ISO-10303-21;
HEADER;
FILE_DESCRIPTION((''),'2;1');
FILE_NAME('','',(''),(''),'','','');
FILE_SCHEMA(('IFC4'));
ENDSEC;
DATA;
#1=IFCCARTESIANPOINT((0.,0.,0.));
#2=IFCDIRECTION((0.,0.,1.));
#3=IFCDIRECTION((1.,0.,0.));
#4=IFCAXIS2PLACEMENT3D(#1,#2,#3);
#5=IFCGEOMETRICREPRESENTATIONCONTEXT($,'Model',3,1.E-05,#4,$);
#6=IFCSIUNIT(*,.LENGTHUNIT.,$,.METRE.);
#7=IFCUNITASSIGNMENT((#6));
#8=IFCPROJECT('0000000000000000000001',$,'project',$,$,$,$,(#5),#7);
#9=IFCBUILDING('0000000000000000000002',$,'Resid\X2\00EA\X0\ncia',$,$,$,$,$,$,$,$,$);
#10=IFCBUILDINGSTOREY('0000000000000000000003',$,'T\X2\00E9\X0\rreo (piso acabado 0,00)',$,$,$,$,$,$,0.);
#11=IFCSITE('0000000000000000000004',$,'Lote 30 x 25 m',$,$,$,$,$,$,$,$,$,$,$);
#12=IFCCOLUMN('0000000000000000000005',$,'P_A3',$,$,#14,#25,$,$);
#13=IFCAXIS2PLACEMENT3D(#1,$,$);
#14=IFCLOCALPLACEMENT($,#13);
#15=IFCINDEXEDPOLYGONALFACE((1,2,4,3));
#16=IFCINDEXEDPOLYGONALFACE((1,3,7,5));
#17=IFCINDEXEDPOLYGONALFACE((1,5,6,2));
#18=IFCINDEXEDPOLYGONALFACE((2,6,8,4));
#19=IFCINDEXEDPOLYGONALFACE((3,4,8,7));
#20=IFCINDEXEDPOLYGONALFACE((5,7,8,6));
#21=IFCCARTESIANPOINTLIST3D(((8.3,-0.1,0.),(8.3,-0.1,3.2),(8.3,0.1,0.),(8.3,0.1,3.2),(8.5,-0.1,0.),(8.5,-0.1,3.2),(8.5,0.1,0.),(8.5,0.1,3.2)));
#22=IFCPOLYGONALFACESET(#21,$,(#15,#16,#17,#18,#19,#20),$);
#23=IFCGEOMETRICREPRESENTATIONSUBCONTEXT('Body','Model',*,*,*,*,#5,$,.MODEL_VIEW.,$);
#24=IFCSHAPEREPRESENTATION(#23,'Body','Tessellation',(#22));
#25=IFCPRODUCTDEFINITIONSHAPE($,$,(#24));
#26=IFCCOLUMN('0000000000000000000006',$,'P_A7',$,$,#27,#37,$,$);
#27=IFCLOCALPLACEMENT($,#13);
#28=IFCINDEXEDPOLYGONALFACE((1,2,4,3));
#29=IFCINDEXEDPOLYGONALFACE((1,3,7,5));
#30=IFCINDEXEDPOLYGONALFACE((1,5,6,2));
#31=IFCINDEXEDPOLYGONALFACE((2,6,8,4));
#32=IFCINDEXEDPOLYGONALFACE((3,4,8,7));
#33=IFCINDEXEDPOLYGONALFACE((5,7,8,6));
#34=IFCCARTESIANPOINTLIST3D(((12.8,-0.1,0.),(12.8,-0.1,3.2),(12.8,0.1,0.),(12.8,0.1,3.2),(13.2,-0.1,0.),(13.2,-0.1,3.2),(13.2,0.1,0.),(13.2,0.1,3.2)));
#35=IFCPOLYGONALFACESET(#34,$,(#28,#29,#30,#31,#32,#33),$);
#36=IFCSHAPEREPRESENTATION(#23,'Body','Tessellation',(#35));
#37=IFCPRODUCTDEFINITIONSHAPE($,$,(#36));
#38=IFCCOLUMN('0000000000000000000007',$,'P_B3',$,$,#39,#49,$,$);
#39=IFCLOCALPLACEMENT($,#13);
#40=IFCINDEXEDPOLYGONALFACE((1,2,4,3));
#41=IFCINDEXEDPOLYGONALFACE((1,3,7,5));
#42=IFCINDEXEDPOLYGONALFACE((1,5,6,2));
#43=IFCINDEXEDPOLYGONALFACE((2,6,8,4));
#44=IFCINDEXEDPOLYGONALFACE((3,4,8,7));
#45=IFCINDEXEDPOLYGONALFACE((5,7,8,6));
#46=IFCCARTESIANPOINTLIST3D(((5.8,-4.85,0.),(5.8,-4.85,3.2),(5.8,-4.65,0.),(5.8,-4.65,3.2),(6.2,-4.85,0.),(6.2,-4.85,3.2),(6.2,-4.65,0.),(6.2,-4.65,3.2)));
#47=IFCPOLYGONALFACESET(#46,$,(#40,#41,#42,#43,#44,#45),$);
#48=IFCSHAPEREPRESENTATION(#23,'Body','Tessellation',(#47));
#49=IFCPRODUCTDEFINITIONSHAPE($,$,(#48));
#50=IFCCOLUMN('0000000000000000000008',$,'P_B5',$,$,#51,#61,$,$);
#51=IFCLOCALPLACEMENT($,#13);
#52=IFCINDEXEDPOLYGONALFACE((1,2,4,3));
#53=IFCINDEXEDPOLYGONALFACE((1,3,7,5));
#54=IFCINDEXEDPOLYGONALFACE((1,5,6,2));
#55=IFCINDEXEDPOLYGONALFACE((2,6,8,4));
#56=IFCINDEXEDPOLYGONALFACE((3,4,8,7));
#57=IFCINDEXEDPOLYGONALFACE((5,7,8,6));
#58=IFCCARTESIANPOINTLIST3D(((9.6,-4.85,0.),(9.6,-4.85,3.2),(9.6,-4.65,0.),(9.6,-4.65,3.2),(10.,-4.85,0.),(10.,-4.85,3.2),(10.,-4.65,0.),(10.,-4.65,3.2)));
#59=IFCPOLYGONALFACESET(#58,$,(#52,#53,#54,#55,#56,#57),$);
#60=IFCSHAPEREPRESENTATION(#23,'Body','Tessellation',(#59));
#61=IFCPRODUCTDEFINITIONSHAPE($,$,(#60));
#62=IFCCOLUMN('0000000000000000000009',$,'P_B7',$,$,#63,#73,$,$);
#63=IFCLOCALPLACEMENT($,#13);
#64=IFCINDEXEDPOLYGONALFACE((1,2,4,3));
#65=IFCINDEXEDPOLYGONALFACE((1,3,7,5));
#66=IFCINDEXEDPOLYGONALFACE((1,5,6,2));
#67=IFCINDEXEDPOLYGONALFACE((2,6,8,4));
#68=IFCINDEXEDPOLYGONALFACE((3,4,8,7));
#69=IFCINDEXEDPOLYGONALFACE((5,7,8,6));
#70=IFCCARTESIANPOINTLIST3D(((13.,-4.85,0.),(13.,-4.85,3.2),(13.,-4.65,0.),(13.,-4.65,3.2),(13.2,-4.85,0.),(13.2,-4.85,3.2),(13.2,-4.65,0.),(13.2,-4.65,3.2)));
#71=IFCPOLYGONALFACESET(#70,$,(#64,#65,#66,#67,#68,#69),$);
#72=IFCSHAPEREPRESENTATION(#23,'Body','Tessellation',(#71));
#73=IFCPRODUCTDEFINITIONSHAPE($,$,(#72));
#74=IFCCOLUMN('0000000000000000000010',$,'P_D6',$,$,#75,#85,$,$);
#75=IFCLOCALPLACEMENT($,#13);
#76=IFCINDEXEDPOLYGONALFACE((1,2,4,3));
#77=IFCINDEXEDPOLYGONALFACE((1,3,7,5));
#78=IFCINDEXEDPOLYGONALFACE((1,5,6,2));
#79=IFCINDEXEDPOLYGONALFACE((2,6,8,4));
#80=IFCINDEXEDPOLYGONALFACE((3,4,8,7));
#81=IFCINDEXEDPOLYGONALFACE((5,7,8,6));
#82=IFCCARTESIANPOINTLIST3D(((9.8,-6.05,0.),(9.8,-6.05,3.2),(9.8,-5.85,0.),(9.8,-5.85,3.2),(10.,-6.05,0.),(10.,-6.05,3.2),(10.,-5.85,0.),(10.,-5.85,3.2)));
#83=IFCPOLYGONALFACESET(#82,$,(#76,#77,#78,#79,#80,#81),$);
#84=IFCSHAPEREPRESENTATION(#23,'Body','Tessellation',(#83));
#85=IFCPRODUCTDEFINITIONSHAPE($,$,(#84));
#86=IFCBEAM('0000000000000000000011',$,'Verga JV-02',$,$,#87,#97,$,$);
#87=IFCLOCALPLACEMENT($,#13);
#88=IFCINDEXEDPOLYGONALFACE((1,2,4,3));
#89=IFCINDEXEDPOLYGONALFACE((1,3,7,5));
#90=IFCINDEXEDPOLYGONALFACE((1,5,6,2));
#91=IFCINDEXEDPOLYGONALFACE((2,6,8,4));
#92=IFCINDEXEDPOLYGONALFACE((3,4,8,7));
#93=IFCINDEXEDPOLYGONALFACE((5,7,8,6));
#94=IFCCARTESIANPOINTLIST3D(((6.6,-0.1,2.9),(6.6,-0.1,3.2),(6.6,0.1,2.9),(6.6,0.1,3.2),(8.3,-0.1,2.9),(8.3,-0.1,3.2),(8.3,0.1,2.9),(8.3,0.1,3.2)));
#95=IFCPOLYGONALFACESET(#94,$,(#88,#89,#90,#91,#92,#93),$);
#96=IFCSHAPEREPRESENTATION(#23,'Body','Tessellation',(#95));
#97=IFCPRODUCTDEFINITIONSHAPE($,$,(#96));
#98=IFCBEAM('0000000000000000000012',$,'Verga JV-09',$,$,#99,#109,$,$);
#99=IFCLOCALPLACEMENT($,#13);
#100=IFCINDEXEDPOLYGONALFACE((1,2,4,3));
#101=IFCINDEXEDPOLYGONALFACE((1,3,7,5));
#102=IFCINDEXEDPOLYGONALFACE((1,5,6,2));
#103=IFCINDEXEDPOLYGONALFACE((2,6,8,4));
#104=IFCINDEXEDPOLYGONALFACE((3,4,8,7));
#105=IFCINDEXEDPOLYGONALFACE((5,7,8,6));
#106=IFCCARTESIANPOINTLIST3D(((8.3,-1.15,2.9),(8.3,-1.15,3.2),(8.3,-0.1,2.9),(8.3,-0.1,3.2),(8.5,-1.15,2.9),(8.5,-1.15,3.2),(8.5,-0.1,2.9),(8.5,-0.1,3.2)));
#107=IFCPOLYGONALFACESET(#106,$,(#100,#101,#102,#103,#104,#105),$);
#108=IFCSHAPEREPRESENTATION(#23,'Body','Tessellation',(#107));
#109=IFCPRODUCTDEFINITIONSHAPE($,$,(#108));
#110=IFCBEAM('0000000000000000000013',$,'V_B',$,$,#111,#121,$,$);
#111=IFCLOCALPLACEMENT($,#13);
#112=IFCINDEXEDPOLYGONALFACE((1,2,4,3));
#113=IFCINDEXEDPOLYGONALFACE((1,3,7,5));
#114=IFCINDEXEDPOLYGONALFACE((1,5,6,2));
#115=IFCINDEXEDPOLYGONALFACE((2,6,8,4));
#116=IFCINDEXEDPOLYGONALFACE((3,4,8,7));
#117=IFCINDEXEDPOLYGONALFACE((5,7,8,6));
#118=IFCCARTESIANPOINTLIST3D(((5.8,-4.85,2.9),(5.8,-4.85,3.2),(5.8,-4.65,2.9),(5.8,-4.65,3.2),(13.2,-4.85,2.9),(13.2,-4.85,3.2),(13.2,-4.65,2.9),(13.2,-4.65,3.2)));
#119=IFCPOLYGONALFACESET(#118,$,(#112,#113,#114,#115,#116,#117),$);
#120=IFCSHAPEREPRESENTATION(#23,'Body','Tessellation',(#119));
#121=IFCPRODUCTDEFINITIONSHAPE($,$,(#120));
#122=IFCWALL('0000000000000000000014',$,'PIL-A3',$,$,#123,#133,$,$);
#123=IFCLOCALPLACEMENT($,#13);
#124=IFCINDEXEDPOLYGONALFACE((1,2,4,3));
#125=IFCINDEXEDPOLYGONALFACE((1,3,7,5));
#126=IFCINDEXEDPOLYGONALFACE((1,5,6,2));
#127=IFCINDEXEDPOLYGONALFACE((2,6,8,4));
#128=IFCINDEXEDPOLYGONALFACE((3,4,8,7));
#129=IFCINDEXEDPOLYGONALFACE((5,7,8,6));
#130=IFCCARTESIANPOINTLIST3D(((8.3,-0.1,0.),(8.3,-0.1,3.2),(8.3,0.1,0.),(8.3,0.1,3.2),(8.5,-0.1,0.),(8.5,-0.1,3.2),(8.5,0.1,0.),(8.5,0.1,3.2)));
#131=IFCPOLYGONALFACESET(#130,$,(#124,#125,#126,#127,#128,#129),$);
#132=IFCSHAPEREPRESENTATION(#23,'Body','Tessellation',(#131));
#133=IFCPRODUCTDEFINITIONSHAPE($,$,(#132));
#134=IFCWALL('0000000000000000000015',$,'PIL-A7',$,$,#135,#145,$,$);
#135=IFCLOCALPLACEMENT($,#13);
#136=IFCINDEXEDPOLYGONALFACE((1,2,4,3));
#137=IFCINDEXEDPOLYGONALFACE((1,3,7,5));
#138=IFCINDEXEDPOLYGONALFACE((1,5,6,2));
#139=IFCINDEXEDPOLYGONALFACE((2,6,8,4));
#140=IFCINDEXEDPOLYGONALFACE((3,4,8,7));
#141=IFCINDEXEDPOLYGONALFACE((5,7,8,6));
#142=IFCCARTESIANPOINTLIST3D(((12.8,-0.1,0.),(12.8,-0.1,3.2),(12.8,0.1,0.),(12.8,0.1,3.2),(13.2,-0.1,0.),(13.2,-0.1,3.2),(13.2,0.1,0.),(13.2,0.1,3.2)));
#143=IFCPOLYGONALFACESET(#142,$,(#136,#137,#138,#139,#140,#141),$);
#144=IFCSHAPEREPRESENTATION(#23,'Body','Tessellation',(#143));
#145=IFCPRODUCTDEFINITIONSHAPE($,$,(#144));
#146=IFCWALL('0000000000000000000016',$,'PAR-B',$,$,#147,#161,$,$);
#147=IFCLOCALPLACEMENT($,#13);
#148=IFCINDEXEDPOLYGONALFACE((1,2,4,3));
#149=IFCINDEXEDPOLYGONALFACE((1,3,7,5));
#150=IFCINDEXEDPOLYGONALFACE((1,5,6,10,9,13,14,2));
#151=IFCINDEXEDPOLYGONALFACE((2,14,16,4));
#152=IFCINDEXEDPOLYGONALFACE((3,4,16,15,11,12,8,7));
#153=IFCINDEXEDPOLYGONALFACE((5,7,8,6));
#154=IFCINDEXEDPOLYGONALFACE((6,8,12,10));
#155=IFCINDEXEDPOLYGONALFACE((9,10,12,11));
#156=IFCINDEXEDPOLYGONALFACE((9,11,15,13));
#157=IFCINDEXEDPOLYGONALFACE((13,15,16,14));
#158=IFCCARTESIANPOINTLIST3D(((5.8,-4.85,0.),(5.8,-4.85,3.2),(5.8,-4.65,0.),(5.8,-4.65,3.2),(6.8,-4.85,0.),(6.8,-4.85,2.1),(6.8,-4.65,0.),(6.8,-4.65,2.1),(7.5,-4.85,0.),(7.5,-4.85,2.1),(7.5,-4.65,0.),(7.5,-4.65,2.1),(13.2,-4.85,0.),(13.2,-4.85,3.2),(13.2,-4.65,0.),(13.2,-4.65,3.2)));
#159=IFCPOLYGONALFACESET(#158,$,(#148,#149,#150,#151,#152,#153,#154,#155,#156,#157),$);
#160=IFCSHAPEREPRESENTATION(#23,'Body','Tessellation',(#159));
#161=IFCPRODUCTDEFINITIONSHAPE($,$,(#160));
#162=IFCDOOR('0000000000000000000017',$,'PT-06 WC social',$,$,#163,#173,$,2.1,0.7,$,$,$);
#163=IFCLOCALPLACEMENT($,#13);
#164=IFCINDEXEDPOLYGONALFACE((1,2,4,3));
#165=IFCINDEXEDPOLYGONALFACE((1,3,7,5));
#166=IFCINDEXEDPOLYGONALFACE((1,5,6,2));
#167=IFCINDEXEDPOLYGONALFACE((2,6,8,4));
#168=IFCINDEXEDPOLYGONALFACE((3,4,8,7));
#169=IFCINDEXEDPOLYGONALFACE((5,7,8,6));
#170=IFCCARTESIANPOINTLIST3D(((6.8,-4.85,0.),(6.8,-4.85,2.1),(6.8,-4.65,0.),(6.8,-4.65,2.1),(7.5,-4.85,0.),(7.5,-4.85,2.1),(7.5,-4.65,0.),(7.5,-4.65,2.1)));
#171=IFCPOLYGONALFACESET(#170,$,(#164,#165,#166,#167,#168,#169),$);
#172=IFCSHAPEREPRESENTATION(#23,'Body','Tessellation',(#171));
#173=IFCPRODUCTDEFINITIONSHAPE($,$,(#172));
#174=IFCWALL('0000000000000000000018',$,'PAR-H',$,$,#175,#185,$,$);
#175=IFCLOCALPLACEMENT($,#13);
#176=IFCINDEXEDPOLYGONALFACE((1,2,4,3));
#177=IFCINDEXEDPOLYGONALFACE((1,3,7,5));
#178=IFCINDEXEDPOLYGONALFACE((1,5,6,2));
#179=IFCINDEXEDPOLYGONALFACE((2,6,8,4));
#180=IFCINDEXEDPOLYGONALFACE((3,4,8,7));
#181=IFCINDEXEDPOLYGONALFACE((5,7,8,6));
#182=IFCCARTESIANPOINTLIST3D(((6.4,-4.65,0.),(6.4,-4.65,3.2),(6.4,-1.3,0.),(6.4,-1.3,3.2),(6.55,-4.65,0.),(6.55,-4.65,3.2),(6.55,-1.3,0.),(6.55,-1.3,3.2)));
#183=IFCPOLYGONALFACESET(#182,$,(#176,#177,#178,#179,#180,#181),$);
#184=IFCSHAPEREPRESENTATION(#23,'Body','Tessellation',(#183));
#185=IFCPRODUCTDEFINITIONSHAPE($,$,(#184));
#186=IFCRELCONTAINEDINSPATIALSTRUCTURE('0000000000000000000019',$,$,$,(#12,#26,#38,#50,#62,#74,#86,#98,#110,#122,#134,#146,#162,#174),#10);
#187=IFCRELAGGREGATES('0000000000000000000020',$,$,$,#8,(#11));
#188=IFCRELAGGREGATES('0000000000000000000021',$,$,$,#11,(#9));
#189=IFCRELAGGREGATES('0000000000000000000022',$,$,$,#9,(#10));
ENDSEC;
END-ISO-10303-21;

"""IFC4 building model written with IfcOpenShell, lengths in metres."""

from ifc_helpers import new_model, si_unit, frame, origin_with_axes, place, context, subcontext, project, spatial, line, indexed_curve, outline, extrude, element, fill, save


model = new_model("IFC4")

# Units and contexts
model_context = context("Model", 3, precision=1e-05, world=origin_with_axes())
body_context = subcontext(model_context, "Body", "Model", "MODEL_VIEW")
ifc_project = project(units=[si_unit("LENGTHUNIT", "METRE")], contexts=[model_context])

# Site, building, storey
site = spatial("IfcSite", under=ifc_project, Name="Lote 30 x 25 m")
building = spatial("IfcBuilding", under=site, Name="Residência")
storey = spatial("IfcBuildingStorey", under=building, Name="Térreo (piso acabado 0,00)", Elevation=0.0)

# Columns
column_1_placement = place(None, frame((8.3, -0.1, 0.0), z_axis=(0.0, 0.0, 1.0), x_axis=(1.0, 0.0, 0.0)))
element("IfcColumn", 1, at=column_1_placement, inside=storey, Name="P_A3", context=body_context, shape_type="SweptSolid", body=[
    extrude(outline(indexed_curve([(0.0, 0.0), (0.2, 0.0), (0.2, 0.2), (0.0, 0.2)], segments=[line(1, 2, 3, 4, 1)])), origin_with_axes(), (0.0, 0.0, 1.0), 3.2),
])
column_2_placement = place(None, frame((12.8, -0.1, 0.0), z_axis=(0.0, 0.0, 1.0), x_axis=(1.0, 0.0, 0.0)))
element("IfcColumn", 2, at=column_2_placement, inside=storey, Name="P_A7", context=body_context, shape_type="SweptSolid", body=[
    extrude(outline(indexed_curve([(0.0, 0.0), (0.4, 0.0), (0.4, 0.2), (0.0, 0.2)], segments=[line(1, 2, 3, 4, 1)])), origin_with_axes(), (0.0, 0.0, 1.0), 3.2),
])
column_3_placement = place(None, frame((5.8, -4.85, 0.0), z_axis=(0.0, 0.0, 1.0), x_axis=(1.0, 0.0, 0.0)))
element("IfcColumn", 3, at=column_3_placement, inside=storey, Name="P_B3", context=body_context, shape_type="SweptSolid", body=[
    extrude(outline(indexed_curve([(0.0, 0.0), (0.4, 0.0), (0.4, 0.2), (0.0, 0.2)], segments=[line(1, 2, 3, 4, 1)])), origin_with_axes(), (0.0, 0.0, 1.0), 3.2),
])
column_4_placement = place(None, frame((9.6, -4.85, 0.0), z_axis=(0.0, 0.0, 1.0), x_axis=(1.0, 0.0, 0.0)))
element("IfcColumn", 4, at=column_4_placement, inside=storey, Name="P_B5", context=body_context, shape_type="SweptSolid", body=[
    extrude(outline(indexed_curve([(0.0, 0.0), (0.4, 0.0), (0.4, 0.2), (0.0, 0.2)], segments=[line(1, 2, 3, 4, 1)])), origin_with_axes(), (0.0, 0.0, 1.0), 3.2),
])
for number, where, z_axis, x_axis, name in (
    (5, (13.0, -4.85, 0.0), (0.0, 0.0, 1.0), (1.0, 0.0, 0.0), "P_B7"),
    (6, (9.8, -6.05, 0.0), (0.0, 0.0, 1.0), (1.0, 0.0, 0.0), "P_D6"),
):
    element("IfcColumn", number, at=place(None, frame(where, z_axis=z_axis, x_axis=x_axis)), inside=storey, Name=name, context=body_context, shape_type="SweptSolid", body=[
        extrude(outline(indexed_curve([(0.0, 0.0), (0.2, 0.0), (0.2, 0.2), (0.0, 0.2)], segments=[line(1, 2, 3, 4, 1)])), origin_with_axes(), (0.0, 0.0, 1.0), 3.2),
    ])

# Beams
beam_1_placement = place(None, frame((6.6, -0.1, 2.9), z_axis=(0.0, 0.0, 1.0), x_axis=(1.0, 0.0, 0.0)))
element("IfcBeam", 7, at=beam_1_placement, inside=storey, Name="Verga JV-02", context=body_context, shape_type="SweptSolid", body=[
    extrude(outline(indexed_curve([(0.0, 0.0), (1.7, 0.0), (1.7, 0.2), (0.0, 0.2)], segments=[line(1, 2, 3, 4, 1)])), origin_with_axes(), (0.0, 0.0, 1.0), 0.3),
])
beam_2_placement = place(None, frame((8.3, -1.15, 2.9), z_axis=(0.0, 0.0, 1.0), x_axis=(1.0, 0.0, 0.0)))
element("IfcBeam", 8, at=beam_2_placement, inside=storey, Name="Verga JV-09", context=body_context, shape_type="SweptSolid", body=[
    extrude(outline(indexed_curve([(0.0, 0.0), (0.2, 0.0), (0.2, 1.05), (0.0, 1.05)], segments=[line(1, 2, 3, 4, 1)])), origin_with_axes(), (0.0, 0.0, 1.0), 0.3),
])
beam_3_placement = place(None, frame((5.8, -4.85, 2.9), z_axis=(0.0, 0.0, 1.0), x_axis=(1.0, 0.0, 0.0)))
element("IfcBeam", 9, at=beam_3_placement, inside=storey, Name="V_B", context=body_context, shape_type="SweptSolid", body=[
    extrude(outline(indexed_curve([(0.0, 0.0), (7.4, 0.0), (7.4, 0.2), (0.0, 0.2)], segments=[line(1, 2, 3, 4, 1)])), origin_with_axes(), (0.0, 0.0, 1.0), 0.3),
])

# Walls
wall_1_placement = place(None, frame((8.3, -0.1, 0.0), z_axis=(0.0, 0.0, 1.0), x_axis=(1.0, 0.0, 0.0)))
element("IfcWall", 10, at=wall_1_placement, inside=storey, Name="PIL-A3", context=body_context, shape_type="SweptSolid", body=[
    extrude(outline(indexed_curve([(0.0, 0.0), (0.2, 0.0), (0.2, 0.2), (0.0, 0.2)], segments=[line(1, 2, 3, 4, 1)])), origin_with_axes(), (0.0, 0.0, 1.0), 3.2),
])
wall_2_placement = place(None, frame((12.8, -0.1, 0.0), z_axis=(0.0, 0.0, 1.0), x_axis=(1.0, 0.0, 0.0)))
element("IfcWall", 11, at=wall_2_placement, inside=storey, Name="PIL-A7", context=body_context, shape_type="SweptSolid", body=[
    extrude(outline(indexed_curve([(0.0, 0.0), (0.4, 0.0), (0.4, 0.2), (0.0, 0.2)], segments=[line(1, 2, 3, 4, 1)])), origin_with_axes(), (0.0, 0.0, 1.0), 3.2),
])

# Wall, opening, door
wall_3_placement = place(None, frame((5.8, -4.85, 0.0), z_axis=(0.0, 0.0, 1.0), x_axis=(1.0, 0.0, 0.0)))
wall_3 = element("IfcWall", 12, at=wall_3_placement, inside=storey, Name="PAR-B", context=body_context, shape_type="SweptSolid", body=[
    extrude(outline(indexed_curve([(0.0, 0.0), (7.4, 0.0), (7.4, 0.2), (0.0, 0.2)], segments=[line(1, 2, 3, 4, 1)])), origin_with_axes(), (0.0, 0.0, 1.0), 3.2),
])
opening_1_placement = place(wall_3_placement, frame((1.0, -0.01, 0.0), z_axis=(0.0, 0.0, 1.0), x_axis=(1.0, 0.0, 0.0)))
opening_1 = element("IfcOpeningElement", 13, at=opening_1_placement, cuts=wall_3, context=body_context, shape_type="SweptSolid", body=[
    extrude(outline(indexed_curve([(0.0, 0.0), (0.7, 0.0), (0.7, 0.22), (0.0, 0.22)], segments=[line(1, 2, 3, 4, 1)])), origin_with_axes(), (0.0, 0.0, 1.0), 2.1),
])
door_1_placement = place(None, frame((6.8, -4.85, 0.0), z_axis=(0.0, 0.0, 1.0), x_axis=(1.0, 0.0, 0.0)))
door_1 = element("IfcDoor", 14, at=door_1_placement, inside=storey, Name="PT-06 WC social", OverallHeight=2.1, OverallWidth=0.7, context=body_context, shape_type="SweptSolid", body=[
    extrude(outline(indexed_curve([(0.0, 0.0), (0.7, 0.0), (0.7, 0.2), (0.0, 0.2)], segments=[line(1, 2, 3, 4, 1)])), origin_with_axes(), (0.0, 0.0, 1.0), 2.1),
])
fill(opening_1, door_1)

# Wall
wall_4_placement = place(None, frame((6.4, -4.65, 0.0), z_axis=(0.0, 0.0, 1.0), x_axis=(1.0, 0.0, 0.0)))
element("IfcWall", 15, at=wall_4_placement, inside=storey, Name="PAR-H", context=body_context, shape_type="SweptSolid", body=[
    extrude(outline(indexed_curve([(0.0, 0.0), (0.15, 0.0), (0.15, 3.35), (0.0, 3.35)], segments=[line(1, 2, 3, 4, 1)])), origin_with_axes(), (0.0, 0.0, 1.0), 3.2),
])

save(model, "model.ifc")
